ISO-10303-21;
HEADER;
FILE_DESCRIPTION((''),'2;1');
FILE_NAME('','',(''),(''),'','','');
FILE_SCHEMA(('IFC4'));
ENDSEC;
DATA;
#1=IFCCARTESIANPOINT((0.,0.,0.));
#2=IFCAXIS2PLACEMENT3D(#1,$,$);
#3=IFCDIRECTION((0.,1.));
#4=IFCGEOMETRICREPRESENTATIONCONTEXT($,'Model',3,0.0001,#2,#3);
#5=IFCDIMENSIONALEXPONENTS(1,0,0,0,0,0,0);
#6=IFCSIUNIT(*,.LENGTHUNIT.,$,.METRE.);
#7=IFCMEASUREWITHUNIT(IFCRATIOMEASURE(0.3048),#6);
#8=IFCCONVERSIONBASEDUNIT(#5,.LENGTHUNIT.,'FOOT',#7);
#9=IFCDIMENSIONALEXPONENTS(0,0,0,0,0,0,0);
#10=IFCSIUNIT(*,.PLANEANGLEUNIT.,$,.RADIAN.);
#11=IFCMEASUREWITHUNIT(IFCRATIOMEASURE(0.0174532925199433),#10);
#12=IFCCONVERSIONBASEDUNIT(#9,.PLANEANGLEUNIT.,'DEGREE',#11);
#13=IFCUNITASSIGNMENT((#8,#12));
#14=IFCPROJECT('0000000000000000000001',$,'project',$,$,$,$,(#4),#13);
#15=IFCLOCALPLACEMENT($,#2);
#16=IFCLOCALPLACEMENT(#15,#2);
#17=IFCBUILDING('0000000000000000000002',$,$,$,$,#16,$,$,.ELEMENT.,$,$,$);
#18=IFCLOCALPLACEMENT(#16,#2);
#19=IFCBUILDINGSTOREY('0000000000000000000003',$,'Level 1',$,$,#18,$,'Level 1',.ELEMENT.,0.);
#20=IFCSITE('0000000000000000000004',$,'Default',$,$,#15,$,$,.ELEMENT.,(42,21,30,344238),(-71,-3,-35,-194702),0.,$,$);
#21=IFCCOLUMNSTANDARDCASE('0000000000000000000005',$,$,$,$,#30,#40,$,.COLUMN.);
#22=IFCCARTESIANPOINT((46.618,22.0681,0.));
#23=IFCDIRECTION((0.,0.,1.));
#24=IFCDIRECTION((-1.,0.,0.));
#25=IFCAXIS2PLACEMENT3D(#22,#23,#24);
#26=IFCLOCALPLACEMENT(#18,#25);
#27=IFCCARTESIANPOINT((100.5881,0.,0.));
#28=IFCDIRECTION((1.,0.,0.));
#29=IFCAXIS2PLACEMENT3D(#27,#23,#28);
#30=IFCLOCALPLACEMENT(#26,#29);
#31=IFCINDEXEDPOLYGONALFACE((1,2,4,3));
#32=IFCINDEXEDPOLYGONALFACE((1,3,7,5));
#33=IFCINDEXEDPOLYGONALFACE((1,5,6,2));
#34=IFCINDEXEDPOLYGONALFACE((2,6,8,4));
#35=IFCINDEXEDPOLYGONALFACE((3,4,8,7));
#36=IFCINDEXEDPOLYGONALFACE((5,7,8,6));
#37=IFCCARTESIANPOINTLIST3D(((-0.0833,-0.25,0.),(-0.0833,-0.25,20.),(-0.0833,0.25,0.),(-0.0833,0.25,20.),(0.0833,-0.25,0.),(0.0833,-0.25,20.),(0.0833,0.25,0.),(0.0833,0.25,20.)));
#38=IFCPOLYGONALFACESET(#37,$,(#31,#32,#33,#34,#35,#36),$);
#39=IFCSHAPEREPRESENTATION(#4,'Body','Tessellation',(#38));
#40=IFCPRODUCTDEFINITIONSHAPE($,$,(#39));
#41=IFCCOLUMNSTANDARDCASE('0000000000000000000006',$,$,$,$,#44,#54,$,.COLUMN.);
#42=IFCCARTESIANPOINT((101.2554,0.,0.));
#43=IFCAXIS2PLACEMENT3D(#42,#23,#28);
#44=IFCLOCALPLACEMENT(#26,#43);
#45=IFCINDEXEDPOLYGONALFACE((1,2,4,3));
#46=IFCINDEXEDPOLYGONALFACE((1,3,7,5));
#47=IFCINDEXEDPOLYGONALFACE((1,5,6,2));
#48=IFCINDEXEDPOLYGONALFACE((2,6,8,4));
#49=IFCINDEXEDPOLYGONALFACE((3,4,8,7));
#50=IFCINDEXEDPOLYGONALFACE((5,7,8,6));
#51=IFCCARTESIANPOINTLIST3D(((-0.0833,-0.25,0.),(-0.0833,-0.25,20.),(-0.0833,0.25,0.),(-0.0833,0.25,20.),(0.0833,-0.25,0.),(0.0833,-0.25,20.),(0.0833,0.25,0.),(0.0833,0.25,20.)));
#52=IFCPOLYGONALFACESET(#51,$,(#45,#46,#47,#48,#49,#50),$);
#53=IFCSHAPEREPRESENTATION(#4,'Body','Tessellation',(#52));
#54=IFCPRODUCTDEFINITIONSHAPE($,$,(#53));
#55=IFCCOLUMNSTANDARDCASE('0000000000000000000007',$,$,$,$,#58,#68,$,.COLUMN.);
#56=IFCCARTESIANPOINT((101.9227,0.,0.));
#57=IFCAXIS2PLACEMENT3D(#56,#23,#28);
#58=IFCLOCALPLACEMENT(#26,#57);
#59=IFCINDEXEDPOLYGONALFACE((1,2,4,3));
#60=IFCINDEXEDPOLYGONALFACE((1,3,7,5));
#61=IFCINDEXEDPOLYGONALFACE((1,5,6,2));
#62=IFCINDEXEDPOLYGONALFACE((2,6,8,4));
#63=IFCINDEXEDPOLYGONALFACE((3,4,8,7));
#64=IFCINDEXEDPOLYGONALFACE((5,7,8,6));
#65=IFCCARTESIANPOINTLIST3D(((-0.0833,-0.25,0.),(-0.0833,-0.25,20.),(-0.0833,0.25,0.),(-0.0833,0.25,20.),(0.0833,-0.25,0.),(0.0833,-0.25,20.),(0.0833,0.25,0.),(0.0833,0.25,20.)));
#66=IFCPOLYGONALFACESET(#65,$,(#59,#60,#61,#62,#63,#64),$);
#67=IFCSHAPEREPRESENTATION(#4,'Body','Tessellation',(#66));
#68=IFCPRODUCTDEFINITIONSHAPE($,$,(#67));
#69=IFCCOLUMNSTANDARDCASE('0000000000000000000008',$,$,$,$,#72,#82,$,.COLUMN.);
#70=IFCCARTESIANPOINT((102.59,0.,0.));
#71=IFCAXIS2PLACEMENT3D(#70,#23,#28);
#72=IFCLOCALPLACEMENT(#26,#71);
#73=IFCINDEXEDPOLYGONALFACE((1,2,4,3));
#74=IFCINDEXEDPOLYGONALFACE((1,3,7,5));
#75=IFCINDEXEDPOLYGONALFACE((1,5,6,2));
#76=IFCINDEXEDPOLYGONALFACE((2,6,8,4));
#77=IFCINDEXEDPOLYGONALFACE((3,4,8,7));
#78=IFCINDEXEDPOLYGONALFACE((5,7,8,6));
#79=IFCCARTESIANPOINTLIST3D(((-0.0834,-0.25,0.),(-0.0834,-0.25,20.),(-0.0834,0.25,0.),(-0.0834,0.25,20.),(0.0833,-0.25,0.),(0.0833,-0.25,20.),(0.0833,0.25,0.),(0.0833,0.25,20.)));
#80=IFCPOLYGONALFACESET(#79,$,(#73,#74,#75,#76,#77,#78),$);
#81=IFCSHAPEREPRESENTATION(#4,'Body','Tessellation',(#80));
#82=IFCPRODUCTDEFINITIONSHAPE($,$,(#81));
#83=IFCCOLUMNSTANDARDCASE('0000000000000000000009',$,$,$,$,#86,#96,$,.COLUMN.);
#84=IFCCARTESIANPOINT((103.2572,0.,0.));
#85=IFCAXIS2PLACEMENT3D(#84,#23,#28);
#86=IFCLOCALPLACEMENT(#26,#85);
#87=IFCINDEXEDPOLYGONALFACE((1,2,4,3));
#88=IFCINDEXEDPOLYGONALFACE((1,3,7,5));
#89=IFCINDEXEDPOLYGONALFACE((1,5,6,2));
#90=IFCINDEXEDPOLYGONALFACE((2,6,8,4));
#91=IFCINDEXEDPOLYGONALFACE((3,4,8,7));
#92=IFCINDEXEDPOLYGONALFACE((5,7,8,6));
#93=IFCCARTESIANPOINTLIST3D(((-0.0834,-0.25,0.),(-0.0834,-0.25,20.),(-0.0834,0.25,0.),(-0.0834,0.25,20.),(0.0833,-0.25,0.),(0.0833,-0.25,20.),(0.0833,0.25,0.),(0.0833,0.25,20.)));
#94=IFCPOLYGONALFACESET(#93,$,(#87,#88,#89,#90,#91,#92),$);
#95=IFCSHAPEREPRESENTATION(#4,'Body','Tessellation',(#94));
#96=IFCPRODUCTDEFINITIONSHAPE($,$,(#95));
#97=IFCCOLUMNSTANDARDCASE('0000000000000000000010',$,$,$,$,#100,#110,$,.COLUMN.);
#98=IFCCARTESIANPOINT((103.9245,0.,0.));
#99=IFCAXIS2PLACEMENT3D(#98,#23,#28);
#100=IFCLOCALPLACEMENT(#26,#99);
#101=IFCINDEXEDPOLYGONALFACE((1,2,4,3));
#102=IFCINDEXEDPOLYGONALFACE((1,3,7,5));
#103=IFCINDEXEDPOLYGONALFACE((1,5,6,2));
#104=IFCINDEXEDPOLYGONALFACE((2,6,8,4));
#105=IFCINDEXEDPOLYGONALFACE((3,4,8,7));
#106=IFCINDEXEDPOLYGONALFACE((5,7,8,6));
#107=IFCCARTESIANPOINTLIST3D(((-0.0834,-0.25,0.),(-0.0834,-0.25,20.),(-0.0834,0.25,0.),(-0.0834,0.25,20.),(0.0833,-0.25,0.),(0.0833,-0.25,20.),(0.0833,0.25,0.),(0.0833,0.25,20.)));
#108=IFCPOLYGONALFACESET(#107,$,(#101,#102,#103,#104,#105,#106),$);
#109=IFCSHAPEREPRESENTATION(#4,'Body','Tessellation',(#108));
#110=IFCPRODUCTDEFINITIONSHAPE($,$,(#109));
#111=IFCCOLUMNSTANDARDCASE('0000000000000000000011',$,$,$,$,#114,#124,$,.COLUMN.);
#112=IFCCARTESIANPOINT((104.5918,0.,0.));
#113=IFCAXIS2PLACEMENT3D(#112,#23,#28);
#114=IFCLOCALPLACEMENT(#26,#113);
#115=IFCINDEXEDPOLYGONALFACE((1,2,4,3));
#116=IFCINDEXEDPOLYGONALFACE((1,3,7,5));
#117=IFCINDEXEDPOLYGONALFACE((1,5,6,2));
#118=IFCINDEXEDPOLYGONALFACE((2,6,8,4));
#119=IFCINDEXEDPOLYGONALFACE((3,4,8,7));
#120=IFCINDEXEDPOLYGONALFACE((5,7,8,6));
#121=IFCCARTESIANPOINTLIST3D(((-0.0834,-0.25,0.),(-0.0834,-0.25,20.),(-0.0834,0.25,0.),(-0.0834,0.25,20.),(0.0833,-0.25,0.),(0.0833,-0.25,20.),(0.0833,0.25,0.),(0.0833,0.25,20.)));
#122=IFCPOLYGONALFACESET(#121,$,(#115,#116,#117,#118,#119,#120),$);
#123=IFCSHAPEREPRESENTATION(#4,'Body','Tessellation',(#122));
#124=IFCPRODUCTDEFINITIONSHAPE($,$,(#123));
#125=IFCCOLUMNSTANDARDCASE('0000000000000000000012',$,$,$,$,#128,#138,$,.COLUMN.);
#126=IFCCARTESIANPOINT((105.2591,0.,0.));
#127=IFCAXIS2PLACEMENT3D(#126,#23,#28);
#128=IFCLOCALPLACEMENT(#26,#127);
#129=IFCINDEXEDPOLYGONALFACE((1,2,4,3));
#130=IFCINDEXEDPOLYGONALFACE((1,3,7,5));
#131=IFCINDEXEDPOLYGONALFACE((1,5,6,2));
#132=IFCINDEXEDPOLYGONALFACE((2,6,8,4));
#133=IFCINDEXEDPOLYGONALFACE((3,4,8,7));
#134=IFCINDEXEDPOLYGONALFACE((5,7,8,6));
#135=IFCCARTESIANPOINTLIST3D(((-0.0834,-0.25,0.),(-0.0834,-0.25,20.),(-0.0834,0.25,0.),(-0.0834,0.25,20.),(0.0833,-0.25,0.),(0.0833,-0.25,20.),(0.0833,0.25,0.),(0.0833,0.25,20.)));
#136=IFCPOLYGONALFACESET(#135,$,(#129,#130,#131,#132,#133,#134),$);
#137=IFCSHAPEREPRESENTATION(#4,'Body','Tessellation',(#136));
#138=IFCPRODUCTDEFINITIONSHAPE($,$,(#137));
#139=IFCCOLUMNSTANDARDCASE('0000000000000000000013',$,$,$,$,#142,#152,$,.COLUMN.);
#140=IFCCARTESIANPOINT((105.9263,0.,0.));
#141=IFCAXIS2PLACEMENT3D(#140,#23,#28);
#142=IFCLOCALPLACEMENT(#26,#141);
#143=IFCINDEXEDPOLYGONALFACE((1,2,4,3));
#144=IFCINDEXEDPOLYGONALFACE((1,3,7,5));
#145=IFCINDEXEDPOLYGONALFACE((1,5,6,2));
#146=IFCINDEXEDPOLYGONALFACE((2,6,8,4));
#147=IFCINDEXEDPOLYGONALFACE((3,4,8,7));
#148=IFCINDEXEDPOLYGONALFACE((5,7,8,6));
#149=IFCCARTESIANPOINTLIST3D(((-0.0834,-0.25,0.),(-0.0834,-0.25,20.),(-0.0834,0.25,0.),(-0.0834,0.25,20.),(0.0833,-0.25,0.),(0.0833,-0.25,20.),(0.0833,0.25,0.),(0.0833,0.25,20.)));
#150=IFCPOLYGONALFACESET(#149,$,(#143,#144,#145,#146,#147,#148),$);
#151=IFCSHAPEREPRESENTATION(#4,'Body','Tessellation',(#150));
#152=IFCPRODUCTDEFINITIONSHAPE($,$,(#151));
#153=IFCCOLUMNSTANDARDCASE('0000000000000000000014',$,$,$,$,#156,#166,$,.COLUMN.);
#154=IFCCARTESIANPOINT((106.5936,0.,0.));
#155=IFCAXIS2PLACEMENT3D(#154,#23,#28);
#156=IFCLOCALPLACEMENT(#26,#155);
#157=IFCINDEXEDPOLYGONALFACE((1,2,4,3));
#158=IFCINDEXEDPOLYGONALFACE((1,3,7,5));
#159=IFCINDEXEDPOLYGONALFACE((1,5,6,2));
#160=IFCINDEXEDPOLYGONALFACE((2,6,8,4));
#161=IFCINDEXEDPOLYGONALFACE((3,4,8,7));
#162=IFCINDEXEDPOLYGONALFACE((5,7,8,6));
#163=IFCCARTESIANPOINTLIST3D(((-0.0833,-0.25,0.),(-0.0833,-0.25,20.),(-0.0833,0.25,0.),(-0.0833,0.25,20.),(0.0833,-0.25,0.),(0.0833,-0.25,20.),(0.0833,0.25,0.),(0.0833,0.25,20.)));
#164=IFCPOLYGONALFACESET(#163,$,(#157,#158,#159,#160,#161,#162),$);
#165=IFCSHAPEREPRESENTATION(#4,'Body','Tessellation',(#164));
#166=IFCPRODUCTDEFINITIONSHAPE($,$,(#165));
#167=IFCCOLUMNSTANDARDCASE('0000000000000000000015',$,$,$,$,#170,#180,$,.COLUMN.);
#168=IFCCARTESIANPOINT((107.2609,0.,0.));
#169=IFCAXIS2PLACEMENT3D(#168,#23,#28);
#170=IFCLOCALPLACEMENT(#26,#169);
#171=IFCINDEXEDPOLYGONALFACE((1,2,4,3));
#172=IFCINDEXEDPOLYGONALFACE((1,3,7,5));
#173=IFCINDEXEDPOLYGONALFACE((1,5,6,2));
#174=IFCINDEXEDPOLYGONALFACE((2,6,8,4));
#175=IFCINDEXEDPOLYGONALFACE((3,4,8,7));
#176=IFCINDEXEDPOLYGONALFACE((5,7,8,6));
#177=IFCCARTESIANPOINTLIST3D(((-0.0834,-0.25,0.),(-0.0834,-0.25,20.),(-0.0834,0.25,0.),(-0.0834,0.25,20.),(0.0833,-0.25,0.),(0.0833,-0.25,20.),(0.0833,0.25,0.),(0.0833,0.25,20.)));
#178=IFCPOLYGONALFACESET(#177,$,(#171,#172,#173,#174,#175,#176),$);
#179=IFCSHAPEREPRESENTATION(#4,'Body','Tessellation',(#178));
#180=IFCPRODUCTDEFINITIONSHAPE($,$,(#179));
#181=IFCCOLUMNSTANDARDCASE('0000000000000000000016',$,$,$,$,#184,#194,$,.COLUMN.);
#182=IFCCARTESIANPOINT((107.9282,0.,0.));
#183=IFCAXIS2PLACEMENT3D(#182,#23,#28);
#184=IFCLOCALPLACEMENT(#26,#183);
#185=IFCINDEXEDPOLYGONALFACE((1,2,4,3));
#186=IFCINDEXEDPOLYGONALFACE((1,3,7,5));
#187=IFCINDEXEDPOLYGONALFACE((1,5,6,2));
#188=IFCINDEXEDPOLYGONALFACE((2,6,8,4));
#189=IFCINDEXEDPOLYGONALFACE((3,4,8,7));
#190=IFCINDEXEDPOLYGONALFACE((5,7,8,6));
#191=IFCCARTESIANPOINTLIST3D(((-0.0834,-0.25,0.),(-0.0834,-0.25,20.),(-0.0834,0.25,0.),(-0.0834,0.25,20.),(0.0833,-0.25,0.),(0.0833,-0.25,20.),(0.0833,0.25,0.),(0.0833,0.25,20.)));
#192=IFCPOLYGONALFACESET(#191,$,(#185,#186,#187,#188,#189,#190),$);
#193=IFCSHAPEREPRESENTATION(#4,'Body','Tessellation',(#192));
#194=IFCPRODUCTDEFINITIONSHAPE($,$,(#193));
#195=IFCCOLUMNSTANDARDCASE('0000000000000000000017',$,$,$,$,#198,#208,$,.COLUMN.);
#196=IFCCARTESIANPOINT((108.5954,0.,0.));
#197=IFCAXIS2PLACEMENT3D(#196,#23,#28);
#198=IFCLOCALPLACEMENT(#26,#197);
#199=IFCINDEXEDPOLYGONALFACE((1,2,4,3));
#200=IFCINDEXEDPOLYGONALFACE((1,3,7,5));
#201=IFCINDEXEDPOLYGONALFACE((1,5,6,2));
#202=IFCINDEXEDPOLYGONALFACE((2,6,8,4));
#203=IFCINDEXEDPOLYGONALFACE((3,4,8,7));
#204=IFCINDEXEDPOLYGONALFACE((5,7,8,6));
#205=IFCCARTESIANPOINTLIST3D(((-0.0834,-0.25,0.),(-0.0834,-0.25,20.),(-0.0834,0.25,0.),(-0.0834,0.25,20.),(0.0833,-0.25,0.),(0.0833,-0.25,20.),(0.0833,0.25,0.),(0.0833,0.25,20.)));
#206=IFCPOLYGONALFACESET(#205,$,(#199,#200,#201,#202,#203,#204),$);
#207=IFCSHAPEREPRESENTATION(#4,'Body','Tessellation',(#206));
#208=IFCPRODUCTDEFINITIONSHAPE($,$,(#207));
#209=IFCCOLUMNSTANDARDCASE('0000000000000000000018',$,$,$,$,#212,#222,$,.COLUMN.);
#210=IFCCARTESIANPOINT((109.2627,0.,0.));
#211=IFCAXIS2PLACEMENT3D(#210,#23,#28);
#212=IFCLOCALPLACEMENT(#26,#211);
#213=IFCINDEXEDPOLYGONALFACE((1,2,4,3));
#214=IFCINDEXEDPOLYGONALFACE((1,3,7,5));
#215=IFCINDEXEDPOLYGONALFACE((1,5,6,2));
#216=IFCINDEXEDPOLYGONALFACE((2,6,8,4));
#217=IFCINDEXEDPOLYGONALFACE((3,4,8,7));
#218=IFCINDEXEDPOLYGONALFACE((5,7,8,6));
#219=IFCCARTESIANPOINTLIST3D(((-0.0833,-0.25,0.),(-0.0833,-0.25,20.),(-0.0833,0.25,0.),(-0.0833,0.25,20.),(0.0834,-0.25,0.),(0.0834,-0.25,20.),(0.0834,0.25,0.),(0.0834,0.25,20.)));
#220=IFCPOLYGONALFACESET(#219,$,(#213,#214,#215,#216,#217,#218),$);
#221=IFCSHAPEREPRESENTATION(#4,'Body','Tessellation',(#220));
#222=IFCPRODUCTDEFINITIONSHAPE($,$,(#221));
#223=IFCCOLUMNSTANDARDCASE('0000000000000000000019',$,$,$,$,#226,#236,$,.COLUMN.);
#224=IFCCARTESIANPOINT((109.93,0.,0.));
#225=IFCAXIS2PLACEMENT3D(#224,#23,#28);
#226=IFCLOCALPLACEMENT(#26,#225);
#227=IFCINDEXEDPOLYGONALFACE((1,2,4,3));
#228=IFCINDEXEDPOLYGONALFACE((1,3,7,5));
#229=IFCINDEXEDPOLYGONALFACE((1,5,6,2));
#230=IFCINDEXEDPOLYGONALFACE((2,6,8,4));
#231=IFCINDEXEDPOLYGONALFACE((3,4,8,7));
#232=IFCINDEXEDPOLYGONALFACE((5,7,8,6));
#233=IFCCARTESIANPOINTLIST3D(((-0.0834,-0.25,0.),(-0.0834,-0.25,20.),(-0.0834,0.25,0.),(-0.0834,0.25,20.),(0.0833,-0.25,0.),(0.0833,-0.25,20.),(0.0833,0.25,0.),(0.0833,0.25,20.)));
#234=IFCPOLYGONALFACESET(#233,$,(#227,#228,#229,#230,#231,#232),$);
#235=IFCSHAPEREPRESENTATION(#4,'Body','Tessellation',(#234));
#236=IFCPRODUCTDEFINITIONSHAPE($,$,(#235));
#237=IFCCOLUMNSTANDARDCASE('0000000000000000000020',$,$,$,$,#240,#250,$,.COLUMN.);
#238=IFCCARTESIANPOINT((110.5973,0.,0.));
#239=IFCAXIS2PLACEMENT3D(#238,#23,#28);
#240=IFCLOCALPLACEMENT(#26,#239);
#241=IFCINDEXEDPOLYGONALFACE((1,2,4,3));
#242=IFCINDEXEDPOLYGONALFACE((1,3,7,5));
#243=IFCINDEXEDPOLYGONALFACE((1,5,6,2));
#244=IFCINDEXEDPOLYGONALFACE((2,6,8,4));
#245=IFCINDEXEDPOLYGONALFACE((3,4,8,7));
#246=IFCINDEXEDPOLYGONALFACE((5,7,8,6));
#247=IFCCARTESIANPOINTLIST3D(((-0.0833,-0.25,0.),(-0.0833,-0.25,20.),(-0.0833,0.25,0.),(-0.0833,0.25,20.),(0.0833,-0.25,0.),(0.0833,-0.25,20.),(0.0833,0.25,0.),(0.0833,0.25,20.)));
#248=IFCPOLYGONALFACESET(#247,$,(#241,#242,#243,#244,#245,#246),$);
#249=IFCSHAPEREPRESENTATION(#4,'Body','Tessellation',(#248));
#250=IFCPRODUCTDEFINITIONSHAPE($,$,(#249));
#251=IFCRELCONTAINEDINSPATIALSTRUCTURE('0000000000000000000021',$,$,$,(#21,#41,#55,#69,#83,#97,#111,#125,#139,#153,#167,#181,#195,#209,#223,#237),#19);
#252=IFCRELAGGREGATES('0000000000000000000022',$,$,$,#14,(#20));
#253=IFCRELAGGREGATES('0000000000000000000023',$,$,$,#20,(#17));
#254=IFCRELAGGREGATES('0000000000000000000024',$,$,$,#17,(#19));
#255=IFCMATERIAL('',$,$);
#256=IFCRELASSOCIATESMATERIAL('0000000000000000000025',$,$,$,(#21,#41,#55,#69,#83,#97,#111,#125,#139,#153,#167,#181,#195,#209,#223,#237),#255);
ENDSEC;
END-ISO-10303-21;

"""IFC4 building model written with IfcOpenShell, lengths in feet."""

from ifc_helpers import new_model, entity, si_unit, converted_unit, direction, frame, origin, place, context, project, spatial, rectangle, extrude, material, element, save


model = new_model("IFC4")

# Units and contexts
model_context = context("Model", 3, precision=0.0001, world=origin(), true_north=direction((0.0, 1.0)))
ifc_project = project(units=[converted_unit("LENGTHUNIT", "FOOT", entity("IfcRatioMeasure", 0.3048), si_unit("LENGTHUNIT", "METRE"), dimensions=[1, 0, 0, 0, 0, 0, 0]), converted_unit("PLANEANGLEUNIT", "DEGREE", entity("IfcRatioMeasure", 0.0174532925199433), si_unit("PLANEANGLEUNIT", "RADIAN"), dimensions=[0, 0, 0, 0, 0, 0, 0])], contexts=[model_context])

# Site, building, storey
site_placement = place(None, origin())
site = spatial("IfcSite", under=ifc_project, at=site_placement, Name="Default", CompositionType="ELEMENT", RefLatitude=(42, 21, 30, 344238), RefLongitude=(-71, -3, -35, -194702), RefElevation=0.0)
building_placement = place(site_placement, origin())
building = spatial("IfcBuilding", under=site, at=building_placement, CompositionType="ELEMENT")
storey_placement = place(building_placement, origin())
storey = spatial("IfcBuildingStorey", under=building, at=storey_placement, Name="Level 1", LongName="Level 1", CompositionType="ELEMENT", Elevation=0.0)

# Columns
ifc_material_1 = material(Name="")
placement = place(storey_placement, frame((46.618, 22.0681, 0.0), z_axis=(0.0, 0.0, 1.0), x_axis=(-1.0, 0.0, 0.0)))
for number, where, z_axis, x_axis in (
    (1, (100.5881, 0.0, 0.0), (0.0, 0.0, 1.0), (1.0, 0.0, 0.0)),
    (2, (101.2554, 0.0, 0.0), (0.0, 0.0, 1.0), (1.0, 0.0, 0.0)),
    (3, (101.9227, 0.0, 0.0), (0.0, 0.0, 1.0), (1.0, 0.0, 0.0)),
    (4, (102.59, 0.0, 0.0), (0.0, 0.0, 1.0), (1.0, 0.0, 0.0)),
    (5, (103.2572, 0.0, 0.0), (0.0, 0.0, 1.0), (1.0, 0.0, 0.0)),
    (6, (103.9245, 0.0, 0.0), (0.0, 0.0, 1.0), (1.0, 0.0, 0.0)),
    (7, (104.5918, 0.0, 0.0), (0.0, 0.0, 1.0), (1.0, 0.0, 0.0)),
    (8, (105.2591, 0.0, 0.0), (0.0, 0.0, 1.0), (1.0, 0.0, 0.0)),
    (9, (105.9263, 0.0, 0.0), (0.0, 0.0, 1.0), (1.0, 0.0, 0.0)),
    (10, (106.5936, 0.0, 0.0), (0.0, 0.0, 1.0), (1.0, 0.0, 0.0)),
    (11, (107.2609, 0.0, 0.0), (0.0, 0.0, 1.0), (1.0, 0.0, 0.0)),
    (12, (107.9282, 0.0, 0.0), (0.0, 0.0, 1.0), (1.0, 0.0, 0.0)),
    (13, (108.5954, 0.0, 0.0), (0.0, 0.0, 1.0), (1.0, 0.0, 0.0)),
    (14, (109.2627, 0.0, 0.0), (0.0, 0.0, 1.0), (1.0, 0.0, 0.0)),
    (15, (109.93, 0.0, 0.0), (0.0, 0.0, 1.0), (1.0, 0.0, 0.0)),
    (16, (110.5973, 0.0, 0.0), (0.0, 0.0, 1.0), (1.0, 0.0, 0.0)),
):
    element("IfcColumnStandardCase", number, at=place(placement, frame(where, z_axis=z_axis, x_axis=x_axis)), inside=storey, material=ifc_material_1, PredefinedType="COLUMN", context=model_context, shape_type="SweptSolid", body=[
        extrude(rectangle(XDim=0.1667, YDim=0.5), origin(), (0.0, 0.0, 1.0), 20.0),
    ])

save(model, "model.ifc")
